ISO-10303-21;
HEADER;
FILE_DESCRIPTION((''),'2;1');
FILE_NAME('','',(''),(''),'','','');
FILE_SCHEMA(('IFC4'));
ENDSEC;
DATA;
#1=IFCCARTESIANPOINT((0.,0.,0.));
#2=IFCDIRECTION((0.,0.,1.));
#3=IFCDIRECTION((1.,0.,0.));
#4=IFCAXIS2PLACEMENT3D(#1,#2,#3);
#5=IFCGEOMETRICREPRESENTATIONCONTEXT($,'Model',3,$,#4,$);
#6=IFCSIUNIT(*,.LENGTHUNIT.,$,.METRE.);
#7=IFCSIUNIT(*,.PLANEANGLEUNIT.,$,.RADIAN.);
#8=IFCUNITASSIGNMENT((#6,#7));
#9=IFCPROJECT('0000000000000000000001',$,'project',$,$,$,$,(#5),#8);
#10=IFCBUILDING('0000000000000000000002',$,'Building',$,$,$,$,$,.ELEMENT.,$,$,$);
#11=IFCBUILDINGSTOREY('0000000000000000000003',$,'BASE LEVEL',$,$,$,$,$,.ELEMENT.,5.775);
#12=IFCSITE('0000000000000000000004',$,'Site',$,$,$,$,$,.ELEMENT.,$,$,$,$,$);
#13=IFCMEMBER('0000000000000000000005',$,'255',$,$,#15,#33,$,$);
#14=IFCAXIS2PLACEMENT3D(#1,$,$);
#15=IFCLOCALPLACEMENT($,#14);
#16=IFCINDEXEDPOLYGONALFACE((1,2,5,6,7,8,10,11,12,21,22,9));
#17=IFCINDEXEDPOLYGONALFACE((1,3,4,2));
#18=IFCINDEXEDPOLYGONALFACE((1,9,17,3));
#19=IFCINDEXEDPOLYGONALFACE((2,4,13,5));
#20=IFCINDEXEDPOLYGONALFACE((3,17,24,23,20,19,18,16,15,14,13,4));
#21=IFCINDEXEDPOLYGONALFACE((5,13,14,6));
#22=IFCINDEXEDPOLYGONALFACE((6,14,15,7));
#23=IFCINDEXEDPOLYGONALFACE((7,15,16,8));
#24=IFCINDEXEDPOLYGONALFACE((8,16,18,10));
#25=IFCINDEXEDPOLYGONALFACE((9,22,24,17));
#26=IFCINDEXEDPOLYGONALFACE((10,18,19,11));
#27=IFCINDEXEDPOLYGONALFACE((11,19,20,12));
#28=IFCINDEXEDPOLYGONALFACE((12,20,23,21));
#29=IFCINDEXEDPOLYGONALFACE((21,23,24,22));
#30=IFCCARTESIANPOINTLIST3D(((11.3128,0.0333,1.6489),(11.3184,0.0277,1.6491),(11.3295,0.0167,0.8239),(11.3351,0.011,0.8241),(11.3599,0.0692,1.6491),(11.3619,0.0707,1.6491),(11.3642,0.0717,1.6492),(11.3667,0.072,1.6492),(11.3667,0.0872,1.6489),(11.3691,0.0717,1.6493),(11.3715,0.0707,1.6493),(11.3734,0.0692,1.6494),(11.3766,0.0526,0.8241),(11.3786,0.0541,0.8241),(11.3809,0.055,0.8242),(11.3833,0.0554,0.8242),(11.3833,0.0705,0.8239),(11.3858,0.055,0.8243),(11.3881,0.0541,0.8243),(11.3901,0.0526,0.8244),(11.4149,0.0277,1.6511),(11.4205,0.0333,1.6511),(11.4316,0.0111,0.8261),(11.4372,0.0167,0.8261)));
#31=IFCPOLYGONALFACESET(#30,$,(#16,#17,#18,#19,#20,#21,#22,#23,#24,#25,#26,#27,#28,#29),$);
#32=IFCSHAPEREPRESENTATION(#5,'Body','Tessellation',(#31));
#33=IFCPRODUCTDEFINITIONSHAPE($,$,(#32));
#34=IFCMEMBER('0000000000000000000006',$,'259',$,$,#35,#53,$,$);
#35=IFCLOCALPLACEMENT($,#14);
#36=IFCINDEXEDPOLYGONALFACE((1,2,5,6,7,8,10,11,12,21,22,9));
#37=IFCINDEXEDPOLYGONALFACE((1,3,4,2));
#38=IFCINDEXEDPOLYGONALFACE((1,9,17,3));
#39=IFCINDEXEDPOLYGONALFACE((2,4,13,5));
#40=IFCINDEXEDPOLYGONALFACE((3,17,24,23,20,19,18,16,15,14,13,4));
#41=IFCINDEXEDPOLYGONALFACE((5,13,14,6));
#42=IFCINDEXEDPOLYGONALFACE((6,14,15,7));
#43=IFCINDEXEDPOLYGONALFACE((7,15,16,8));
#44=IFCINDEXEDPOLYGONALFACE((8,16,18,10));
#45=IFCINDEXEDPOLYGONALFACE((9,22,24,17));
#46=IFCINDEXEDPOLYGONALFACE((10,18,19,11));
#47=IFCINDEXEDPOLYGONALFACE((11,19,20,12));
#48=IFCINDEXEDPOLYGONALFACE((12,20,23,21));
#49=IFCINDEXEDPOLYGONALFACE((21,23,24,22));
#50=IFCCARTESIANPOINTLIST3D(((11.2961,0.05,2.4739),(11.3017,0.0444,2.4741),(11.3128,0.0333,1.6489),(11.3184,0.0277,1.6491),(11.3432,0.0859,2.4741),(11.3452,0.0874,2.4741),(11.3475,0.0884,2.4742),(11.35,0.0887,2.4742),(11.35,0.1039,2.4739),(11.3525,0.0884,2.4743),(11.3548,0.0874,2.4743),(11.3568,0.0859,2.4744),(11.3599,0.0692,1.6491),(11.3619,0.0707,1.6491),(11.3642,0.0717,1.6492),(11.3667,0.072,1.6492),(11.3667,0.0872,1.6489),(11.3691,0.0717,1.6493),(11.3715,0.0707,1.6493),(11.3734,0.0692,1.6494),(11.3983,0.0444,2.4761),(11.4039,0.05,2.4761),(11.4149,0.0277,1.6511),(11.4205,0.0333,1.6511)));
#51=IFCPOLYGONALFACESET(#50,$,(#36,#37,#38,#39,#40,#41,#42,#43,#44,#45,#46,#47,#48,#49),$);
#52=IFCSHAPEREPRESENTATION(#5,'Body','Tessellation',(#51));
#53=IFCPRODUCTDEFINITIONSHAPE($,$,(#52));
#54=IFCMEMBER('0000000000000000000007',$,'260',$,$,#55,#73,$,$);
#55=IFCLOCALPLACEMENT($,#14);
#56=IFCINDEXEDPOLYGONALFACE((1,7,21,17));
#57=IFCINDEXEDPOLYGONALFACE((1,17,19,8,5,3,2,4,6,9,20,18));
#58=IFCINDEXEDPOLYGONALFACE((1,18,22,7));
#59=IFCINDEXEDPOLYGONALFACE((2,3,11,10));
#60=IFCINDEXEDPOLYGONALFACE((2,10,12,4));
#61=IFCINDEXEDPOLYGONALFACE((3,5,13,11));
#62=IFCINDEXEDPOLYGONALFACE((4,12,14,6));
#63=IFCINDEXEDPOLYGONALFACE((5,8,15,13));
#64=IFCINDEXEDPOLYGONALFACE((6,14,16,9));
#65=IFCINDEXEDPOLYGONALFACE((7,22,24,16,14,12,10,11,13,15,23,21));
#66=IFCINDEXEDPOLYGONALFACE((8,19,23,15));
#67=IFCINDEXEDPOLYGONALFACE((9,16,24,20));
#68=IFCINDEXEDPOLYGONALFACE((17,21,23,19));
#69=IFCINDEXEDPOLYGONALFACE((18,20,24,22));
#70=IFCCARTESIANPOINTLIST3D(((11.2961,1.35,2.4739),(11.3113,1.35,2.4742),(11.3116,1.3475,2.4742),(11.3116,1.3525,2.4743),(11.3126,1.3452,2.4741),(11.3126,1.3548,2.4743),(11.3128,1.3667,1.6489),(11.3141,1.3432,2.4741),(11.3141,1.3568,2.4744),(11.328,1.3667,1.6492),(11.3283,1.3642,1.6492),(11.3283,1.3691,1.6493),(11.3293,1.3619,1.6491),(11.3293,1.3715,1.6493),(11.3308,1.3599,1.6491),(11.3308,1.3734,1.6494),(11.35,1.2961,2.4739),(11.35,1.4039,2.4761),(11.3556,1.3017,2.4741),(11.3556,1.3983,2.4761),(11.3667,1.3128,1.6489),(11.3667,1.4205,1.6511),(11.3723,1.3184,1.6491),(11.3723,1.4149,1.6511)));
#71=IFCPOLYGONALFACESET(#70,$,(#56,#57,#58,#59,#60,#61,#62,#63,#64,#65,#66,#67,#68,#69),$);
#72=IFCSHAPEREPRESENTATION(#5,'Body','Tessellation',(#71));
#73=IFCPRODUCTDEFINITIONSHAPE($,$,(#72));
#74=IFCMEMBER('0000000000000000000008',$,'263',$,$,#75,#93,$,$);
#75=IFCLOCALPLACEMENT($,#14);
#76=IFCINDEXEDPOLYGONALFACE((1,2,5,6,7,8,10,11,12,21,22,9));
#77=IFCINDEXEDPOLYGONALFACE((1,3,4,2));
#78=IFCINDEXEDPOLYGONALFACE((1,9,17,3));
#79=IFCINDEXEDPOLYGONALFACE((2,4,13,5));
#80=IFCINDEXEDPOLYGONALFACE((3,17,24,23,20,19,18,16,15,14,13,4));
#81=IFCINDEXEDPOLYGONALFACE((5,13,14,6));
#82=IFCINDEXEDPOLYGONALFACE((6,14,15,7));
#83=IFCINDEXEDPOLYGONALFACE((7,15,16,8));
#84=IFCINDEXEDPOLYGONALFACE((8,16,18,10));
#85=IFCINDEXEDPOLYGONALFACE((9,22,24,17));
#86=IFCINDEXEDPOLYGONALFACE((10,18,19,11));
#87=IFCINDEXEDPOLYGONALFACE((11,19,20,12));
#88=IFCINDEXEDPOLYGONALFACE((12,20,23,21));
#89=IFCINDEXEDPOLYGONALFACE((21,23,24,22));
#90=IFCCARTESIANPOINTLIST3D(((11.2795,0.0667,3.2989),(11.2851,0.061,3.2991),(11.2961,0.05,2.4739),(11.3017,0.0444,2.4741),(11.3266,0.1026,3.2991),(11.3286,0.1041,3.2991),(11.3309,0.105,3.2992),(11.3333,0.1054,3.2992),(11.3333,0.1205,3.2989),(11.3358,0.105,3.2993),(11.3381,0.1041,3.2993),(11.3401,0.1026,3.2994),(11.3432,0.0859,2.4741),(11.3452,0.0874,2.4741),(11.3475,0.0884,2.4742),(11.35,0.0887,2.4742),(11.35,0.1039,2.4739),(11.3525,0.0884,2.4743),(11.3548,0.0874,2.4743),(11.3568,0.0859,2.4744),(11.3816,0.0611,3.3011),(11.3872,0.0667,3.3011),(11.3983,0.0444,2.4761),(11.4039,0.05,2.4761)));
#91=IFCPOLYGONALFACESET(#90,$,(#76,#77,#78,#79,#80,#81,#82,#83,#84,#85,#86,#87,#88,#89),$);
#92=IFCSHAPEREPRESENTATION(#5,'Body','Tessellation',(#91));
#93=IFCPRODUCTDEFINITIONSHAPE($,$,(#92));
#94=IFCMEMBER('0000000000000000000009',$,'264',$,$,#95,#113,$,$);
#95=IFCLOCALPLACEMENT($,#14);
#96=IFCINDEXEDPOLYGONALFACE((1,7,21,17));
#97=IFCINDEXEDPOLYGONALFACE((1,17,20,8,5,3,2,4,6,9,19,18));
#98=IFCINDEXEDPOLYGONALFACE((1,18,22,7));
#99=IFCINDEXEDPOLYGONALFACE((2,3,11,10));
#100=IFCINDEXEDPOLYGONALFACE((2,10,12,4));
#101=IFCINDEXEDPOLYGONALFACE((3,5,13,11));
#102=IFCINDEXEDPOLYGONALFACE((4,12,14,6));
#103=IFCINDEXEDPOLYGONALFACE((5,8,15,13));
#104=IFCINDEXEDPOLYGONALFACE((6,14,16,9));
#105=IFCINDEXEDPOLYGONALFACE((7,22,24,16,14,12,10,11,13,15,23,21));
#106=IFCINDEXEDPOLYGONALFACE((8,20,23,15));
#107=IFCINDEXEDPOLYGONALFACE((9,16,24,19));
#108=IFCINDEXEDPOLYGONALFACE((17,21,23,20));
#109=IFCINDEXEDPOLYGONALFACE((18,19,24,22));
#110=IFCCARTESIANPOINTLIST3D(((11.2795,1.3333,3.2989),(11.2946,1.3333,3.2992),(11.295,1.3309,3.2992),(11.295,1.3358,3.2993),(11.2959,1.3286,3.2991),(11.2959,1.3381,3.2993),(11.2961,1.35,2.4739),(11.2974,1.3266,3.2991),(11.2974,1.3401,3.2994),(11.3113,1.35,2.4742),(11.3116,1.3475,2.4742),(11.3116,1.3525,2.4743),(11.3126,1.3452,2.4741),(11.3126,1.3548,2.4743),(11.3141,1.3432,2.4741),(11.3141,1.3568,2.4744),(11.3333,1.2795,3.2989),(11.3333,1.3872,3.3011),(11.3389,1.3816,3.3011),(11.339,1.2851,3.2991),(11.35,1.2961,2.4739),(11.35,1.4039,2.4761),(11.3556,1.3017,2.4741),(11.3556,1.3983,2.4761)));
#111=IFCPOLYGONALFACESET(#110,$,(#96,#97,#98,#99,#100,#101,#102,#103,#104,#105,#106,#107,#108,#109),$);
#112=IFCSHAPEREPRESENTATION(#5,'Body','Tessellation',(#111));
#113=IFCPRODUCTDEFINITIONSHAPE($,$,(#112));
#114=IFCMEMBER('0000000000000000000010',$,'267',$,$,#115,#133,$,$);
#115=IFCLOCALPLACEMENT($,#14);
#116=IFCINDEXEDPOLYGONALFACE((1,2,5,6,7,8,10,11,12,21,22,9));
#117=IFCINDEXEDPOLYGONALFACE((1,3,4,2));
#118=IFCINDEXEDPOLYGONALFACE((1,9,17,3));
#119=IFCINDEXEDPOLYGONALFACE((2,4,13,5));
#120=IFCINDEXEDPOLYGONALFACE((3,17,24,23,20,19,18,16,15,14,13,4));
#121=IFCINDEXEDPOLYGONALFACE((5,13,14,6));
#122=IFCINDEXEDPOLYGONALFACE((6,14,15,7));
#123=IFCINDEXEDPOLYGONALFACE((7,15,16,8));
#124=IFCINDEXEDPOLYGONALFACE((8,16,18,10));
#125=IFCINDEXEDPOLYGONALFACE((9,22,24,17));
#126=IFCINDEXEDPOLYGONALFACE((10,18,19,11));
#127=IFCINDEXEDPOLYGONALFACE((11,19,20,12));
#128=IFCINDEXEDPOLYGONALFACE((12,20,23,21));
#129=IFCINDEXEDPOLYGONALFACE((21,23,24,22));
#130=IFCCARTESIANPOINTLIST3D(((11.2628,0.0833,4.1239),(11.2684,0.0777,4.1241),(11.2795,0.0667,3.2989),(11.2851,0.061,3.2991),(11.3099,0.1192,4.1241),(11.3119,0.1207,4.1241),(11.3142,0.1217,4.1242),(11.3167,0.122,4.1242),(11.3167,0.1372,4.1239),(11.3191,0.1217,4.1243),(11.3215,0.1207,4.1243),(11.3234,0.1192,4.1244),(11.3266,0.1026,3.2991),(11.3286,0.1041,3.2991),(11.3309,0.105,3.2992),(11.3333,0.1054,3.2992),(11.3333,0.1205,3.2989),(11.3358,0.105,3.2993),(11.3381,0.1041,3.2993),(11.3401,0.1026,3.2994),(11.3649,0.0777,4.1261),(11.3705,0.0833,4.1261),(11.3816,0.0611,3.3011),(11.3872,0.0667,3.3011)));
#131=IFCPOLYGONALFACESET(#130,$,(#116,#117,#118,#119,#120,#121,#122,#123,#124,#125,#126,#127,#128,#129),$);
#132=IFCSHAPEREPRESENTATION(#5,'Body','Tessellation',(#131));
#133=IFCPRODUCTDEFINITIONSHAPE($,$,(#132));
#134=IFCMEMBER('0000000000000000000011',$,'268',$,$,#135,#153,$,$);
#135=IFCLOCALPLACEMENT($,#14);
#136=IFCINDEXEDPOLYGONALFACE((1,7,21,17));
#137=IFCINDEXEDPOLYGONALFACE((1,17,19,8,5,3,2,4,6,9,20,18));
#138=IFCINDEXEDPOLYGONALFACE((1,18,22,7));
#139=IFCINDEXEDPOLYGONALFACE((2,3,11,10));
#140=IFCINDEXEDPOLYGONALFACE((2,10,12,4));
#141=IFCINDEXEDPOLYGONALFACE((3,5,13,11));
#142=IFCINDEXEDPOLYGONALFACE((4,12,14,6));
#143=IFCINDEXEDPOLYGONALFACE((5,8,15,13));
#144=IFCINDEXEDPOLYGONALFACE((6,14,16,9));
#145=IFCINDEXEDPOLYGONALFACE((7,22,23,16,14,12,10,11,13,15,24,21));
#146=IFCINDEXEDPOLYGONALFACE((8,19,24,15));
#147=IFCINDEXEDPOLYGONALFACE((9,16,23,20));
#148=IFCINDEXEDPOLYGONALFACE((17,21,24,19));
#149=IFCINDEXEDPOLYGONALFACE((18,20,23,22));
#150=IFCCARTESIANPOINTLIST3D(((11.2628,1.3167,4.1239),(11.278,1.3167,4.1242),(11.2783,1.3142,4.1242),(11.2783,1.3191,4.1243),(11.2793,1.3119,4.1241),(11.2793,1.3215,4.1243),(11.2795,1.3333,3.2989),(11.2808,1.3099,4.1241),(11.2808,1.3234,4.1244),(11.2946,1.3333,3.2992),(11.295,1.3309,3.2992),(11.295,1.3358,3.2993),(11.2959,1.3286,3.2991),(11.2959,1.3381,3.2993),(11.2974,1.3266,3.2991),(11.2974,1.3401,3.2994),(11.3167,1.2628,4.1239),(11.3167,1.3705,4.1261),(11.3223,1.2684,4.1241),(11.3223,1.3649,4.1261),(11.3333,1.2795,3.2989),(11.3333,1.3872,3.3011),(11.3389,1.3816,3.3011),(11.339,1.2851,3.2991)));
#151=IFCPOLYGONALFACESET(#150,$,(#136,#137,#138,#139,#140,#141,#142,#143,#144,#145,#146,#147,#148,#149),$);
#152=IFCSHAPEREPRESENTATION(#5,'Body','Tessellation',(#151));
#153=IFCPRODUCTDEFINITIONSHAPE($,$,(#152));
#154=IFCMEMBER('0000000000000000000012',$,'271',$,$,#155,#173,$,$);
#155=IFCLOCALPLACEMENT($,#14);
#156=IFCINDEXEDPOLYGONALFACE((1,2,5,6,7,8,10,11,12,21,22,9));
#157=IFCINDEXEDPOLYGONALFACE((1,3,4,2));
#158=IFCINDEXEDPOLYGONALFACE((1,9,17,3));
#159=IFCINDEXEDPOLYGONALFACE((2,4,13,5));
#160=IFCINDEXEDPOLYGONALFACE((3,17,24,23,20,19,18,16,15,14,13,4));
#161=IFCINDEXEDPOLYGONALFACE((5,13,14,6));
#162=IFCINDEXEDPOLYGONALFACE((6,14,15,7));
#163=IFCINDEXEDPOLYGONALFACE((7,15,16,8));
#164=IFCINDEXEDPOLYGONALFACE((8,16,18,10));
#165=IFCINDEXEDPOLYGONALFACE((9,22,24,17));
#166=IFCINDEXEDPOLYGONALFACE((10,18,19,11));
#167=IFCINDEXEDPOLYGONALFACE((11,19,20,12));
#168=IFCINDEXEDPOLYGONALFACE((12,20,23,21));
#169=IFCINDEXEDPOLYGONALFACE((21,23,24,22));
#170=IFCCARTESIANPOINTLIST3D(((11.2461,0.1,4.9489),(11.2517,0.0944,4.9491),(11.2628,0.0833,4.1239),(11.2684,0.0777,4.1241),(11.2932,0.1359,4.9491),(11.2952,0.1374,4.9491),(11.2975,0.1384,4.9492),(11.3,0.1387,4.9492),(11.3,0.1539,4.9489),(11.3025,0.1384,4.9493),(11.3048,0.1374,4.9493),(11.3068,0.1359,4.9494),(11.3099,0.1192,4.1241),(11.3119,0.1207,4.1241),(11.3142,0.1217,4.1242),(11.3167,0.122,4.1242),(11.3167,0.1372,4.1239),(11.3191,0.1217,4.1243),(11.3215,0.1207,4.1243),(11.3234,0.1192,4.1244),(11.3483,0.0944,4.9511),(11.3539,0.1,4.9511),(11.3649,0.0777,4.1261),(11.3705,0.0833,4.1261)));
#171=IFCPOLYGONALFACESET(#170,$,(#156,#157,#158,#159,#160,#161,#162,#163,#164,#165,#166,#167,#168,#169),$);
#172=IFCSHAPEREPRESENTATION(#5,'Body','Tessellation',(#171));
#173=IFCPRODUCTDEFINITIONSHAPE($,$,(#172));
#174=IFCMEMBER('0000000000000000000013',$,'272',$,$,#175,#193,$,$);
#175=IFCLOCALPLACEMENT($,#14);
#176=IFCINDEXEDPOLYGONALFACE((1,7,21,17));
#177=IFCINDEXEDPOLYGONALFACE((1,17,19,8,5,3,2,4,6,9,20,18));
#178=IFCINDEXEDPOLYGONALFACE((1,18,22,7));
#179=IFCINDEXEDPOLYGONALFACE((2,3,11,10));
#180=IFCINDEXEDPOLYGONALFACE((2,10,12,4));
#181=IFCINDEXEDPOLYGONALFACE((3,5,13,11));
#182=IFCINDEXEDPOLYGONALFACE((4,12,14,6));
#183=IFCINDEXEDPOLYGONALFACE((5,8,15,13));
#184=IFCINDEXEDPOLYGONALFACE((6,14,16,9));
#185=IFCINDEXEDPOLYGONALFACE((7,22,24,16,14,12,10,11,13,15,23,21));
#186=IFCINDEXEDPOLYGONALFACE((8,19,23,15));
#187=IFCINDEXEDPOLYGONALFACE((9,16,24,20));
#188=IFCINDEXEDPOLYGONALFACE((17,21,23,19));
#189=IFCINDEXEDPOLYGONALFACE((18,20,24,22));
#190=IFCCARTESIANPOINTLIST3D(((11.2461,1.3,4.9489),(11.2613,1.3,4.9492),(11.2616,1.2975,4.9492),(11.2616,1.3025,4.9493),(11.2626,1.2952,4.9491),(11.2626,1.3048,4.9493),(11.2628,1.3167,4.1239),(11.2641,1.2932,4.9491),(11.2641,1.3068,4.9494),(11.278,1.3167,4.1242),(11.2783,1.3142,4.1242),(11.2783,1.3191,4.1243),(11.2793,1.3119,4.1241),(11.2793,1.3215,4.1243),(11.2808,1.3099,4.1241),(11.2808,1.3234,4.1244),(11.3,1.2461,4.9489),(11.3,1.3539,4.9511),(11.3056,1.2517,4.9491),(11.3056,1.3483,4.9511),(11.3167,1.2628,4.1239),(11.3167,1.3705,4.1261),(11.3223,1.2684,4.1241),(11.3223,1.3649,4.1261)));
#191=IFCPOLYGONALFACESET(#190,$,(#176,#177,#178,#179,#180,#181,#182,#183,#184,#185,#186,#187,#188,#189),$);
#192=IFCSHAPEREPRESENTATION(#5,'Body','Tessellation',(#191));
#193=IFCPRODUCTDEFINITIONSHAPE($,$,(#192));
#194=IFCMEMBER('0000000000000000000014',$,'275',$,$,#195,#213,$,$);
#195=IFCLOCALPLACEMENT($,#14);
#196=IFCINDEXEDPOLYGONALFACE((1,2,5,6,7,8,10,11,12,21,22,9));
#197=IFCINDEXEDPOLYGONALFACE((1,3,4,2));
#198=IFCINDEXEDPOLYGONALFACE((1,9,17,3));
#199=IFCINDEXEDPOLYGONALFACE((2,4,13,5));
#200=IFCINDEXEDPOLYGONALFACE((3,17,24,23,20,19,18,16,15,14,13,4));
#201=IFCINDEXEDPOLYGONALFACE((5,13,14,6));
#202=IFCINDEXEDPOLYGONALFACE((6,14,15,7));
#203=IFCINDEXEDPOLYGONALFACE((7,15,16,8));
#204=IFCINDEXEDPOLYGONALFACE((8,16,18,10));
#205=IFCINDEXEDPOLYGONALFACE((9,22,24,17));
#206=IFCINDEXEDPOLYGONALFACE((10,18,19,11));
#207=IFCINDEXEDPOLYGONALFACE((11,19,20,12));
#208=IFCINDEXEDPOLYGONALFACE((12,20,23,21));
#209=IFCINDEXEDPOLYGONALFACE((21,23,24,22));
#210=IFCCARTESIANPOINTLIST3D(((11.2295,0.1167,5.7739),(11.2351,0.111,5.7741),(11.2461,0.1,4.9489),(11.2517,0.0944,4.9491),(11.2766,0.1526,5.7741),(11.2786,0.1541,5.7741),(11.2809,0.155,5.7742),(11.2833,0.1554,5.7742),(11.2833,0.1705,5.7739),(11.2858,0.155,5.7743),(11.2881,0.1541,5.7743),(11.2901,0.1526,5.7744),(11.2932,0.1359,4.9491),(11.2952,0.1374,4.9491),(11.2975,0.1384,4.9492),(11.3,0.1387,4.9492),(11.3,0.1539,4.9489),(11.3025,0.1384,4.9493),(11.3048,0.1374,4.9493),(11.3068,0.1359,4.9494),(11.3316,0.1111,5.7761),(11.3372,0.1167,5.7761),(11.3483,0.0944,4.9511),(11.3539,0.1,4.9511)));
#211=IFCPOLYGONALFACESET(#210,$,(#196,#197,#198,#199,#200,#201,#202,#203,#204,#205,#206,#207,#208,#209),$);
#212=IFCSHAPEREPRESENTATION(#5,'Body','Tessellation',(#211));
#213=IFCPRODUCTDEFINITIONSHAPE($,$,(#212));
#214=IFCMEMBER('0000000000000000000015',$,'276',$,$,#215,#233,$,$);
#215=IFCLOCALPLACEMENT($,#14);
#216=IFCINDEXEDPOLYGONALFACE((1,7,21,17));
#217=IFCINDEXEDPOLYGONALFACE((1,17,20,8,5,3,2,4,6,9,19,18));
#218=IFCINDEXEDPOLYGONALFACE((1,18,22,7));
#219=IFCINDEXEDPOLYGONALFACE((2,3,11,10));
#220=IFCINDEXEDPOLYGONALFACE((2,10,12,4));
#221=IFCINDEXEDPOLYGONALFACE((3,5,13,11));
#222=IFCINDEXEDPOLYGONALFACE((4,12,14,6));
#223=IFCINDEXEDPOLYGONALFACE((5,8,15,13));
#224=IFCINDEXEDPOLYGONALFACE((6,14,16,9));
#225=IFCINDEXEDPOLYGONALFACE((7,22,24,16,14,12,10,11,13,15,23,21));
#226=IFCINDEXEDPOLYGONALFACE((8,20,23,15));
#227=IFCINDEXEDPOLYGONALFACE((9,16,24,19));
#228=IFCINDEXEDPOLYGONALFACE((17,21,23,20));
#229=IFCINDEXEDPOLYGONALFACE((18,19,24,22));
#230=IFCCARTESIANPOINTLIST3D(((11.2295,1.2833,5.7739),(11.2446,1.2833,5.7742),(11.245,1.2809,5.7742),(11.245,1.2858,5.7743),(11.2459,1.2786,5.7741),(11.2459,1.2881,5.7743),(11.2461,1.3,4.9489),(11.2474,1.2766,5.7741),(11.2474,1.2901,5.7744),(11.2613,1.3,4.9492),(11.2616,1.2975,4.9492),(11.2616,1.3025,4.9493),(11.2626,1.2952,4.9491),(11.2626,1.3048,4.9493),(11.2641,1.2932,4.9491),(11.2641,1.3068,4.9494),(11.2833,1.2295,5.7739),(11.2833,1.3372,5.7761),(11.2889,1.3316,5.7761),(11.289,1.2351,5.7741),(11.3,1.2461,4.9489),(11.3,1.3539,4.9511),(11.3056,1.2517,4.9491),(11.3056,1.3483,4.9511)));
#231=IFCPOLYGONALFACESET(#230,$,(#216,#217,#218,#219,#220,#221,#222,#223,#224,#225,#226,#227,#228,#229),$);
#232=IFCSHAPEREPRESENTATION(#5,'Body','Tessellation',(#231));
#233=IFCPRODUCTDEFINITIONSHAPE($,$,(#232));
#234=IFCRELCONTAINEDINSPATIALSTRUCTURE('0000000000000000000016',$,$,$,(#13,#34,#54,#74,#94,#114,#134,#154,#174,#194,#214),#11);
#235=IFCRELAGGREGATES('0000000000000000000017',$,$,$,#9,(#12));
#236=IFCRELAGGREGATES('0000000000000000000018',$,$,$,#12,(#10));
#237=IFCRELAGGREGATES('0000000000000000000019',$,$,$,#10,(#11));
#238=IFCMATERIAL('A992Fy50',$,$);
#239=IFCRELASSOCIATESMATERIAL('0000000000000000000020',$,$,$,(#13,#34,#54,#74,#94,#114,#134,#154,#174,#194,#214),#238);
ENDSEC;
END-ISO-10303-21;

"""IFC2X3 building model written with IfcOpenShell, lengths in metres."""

from ifc_helpers import new_model, si_unit, frame, origin_with_axes, origin_2d_with_axis, place, context, project, spatial, l_section, extrude, material, element, save


model = new_model("IFC2X3")

# Units and contexts
model_context = context("Model", 3, world=origin_with_axes())
ifc_project = project(units=[si_unit("LENGTHUNIT", "METRE"), si_unit("PLANEANGLEUNIT", "RADIAN")], contexts=[model_context])

# Site, building, storey
site = spatial("IfcSite", under=ifc_project, Name="Site", CompositionType="ELEMENT")
building = spatial("IfcBuilding", under=site, Name="Building", CompositionType="ELEMENT")
storey = spatial("IfcBuildingStorey", under=building, Name="BASE LEVEL", CompositionType="ELEMENT", Elevation=5.775)

# Members
ifc_material = material(Name="A992Fy50")
for number, where, z_axis, x_axis, name in (
    (1, (11.3833, 0.0167, 0.825), (-0.020194, 0.020194, 0.999592), (-0.707107, -0.707107, 0.0), "255"),
    (2, (11.3667, 0.0333, 1.65), (-0.020194, 0.020194, 0.999592), (-0.707107, -0.707107, 0.0), "259"),
    (3, (11.3667, 1.3667, 1.65), (-0.020194, -0.020194, 0.999592), (0.707107, -0.707107, 0.0), "260"),
    (4, (11.35, 0.05, 2.475), (-0.020194, 0.020194, 0.999592), (-0.707107, -0.707107, 0.0), "263"),
    (5, (11.35, 1.35, 2.475), (-0.020194, -0.020194, 0.999592), (0.707107, -0.707107, 0.0), "264"),
    (6, (11.3333, 0.0667, 3.3), (-0.020194, 0.020194, 0.999592), (-0.707107, -0.707107, 0.0), "267"),
    (7, (11.3333, 1.3333, 3.3), (-0.020194, -0.020194, 0.999592), (0.707107, -0.707107, 0.0), "268"),
    (8, (11.3167, 0.0833, 4.125), (-0.020194, 0.020194, 0.999592), (-0.707107, -0.707107, 0.0), "271"),
    (9, (11.3167, 1.3167, 4.125), (-0.020194, -0.020194, 0.999592), (0.707107, -0.707107, 0.0), "272"),
    (10, (11.3, 0.1, 4.95), (-0.020194, 0.020194, 0.999592), (-0.707107, -0.707107, 0.0), "275"),
    (11, (11.3, 1.3, 4.95), (-0.020194, -0.020194, 0.999592), (0.707107, -0.707107, 0.0), "276"),
):
    element("IfcMember", number, at=place(None, frame(where, z_axis=z_axis, x_axis=x_axis)), inside=storey, material=ifc_material, Name=name, context=model_context, shape_type="SweptSolid", body=[
        extrude(l_section(Depth=0.0762, Width=0.0762, Thickness=0.0079, FilletRadius=0.0096, at=origin_2d_with_axis()), origin_with_axes(), (0.0, 0.0, 1.0), 0.8253),
    ])

save(model, "model.ifc")
